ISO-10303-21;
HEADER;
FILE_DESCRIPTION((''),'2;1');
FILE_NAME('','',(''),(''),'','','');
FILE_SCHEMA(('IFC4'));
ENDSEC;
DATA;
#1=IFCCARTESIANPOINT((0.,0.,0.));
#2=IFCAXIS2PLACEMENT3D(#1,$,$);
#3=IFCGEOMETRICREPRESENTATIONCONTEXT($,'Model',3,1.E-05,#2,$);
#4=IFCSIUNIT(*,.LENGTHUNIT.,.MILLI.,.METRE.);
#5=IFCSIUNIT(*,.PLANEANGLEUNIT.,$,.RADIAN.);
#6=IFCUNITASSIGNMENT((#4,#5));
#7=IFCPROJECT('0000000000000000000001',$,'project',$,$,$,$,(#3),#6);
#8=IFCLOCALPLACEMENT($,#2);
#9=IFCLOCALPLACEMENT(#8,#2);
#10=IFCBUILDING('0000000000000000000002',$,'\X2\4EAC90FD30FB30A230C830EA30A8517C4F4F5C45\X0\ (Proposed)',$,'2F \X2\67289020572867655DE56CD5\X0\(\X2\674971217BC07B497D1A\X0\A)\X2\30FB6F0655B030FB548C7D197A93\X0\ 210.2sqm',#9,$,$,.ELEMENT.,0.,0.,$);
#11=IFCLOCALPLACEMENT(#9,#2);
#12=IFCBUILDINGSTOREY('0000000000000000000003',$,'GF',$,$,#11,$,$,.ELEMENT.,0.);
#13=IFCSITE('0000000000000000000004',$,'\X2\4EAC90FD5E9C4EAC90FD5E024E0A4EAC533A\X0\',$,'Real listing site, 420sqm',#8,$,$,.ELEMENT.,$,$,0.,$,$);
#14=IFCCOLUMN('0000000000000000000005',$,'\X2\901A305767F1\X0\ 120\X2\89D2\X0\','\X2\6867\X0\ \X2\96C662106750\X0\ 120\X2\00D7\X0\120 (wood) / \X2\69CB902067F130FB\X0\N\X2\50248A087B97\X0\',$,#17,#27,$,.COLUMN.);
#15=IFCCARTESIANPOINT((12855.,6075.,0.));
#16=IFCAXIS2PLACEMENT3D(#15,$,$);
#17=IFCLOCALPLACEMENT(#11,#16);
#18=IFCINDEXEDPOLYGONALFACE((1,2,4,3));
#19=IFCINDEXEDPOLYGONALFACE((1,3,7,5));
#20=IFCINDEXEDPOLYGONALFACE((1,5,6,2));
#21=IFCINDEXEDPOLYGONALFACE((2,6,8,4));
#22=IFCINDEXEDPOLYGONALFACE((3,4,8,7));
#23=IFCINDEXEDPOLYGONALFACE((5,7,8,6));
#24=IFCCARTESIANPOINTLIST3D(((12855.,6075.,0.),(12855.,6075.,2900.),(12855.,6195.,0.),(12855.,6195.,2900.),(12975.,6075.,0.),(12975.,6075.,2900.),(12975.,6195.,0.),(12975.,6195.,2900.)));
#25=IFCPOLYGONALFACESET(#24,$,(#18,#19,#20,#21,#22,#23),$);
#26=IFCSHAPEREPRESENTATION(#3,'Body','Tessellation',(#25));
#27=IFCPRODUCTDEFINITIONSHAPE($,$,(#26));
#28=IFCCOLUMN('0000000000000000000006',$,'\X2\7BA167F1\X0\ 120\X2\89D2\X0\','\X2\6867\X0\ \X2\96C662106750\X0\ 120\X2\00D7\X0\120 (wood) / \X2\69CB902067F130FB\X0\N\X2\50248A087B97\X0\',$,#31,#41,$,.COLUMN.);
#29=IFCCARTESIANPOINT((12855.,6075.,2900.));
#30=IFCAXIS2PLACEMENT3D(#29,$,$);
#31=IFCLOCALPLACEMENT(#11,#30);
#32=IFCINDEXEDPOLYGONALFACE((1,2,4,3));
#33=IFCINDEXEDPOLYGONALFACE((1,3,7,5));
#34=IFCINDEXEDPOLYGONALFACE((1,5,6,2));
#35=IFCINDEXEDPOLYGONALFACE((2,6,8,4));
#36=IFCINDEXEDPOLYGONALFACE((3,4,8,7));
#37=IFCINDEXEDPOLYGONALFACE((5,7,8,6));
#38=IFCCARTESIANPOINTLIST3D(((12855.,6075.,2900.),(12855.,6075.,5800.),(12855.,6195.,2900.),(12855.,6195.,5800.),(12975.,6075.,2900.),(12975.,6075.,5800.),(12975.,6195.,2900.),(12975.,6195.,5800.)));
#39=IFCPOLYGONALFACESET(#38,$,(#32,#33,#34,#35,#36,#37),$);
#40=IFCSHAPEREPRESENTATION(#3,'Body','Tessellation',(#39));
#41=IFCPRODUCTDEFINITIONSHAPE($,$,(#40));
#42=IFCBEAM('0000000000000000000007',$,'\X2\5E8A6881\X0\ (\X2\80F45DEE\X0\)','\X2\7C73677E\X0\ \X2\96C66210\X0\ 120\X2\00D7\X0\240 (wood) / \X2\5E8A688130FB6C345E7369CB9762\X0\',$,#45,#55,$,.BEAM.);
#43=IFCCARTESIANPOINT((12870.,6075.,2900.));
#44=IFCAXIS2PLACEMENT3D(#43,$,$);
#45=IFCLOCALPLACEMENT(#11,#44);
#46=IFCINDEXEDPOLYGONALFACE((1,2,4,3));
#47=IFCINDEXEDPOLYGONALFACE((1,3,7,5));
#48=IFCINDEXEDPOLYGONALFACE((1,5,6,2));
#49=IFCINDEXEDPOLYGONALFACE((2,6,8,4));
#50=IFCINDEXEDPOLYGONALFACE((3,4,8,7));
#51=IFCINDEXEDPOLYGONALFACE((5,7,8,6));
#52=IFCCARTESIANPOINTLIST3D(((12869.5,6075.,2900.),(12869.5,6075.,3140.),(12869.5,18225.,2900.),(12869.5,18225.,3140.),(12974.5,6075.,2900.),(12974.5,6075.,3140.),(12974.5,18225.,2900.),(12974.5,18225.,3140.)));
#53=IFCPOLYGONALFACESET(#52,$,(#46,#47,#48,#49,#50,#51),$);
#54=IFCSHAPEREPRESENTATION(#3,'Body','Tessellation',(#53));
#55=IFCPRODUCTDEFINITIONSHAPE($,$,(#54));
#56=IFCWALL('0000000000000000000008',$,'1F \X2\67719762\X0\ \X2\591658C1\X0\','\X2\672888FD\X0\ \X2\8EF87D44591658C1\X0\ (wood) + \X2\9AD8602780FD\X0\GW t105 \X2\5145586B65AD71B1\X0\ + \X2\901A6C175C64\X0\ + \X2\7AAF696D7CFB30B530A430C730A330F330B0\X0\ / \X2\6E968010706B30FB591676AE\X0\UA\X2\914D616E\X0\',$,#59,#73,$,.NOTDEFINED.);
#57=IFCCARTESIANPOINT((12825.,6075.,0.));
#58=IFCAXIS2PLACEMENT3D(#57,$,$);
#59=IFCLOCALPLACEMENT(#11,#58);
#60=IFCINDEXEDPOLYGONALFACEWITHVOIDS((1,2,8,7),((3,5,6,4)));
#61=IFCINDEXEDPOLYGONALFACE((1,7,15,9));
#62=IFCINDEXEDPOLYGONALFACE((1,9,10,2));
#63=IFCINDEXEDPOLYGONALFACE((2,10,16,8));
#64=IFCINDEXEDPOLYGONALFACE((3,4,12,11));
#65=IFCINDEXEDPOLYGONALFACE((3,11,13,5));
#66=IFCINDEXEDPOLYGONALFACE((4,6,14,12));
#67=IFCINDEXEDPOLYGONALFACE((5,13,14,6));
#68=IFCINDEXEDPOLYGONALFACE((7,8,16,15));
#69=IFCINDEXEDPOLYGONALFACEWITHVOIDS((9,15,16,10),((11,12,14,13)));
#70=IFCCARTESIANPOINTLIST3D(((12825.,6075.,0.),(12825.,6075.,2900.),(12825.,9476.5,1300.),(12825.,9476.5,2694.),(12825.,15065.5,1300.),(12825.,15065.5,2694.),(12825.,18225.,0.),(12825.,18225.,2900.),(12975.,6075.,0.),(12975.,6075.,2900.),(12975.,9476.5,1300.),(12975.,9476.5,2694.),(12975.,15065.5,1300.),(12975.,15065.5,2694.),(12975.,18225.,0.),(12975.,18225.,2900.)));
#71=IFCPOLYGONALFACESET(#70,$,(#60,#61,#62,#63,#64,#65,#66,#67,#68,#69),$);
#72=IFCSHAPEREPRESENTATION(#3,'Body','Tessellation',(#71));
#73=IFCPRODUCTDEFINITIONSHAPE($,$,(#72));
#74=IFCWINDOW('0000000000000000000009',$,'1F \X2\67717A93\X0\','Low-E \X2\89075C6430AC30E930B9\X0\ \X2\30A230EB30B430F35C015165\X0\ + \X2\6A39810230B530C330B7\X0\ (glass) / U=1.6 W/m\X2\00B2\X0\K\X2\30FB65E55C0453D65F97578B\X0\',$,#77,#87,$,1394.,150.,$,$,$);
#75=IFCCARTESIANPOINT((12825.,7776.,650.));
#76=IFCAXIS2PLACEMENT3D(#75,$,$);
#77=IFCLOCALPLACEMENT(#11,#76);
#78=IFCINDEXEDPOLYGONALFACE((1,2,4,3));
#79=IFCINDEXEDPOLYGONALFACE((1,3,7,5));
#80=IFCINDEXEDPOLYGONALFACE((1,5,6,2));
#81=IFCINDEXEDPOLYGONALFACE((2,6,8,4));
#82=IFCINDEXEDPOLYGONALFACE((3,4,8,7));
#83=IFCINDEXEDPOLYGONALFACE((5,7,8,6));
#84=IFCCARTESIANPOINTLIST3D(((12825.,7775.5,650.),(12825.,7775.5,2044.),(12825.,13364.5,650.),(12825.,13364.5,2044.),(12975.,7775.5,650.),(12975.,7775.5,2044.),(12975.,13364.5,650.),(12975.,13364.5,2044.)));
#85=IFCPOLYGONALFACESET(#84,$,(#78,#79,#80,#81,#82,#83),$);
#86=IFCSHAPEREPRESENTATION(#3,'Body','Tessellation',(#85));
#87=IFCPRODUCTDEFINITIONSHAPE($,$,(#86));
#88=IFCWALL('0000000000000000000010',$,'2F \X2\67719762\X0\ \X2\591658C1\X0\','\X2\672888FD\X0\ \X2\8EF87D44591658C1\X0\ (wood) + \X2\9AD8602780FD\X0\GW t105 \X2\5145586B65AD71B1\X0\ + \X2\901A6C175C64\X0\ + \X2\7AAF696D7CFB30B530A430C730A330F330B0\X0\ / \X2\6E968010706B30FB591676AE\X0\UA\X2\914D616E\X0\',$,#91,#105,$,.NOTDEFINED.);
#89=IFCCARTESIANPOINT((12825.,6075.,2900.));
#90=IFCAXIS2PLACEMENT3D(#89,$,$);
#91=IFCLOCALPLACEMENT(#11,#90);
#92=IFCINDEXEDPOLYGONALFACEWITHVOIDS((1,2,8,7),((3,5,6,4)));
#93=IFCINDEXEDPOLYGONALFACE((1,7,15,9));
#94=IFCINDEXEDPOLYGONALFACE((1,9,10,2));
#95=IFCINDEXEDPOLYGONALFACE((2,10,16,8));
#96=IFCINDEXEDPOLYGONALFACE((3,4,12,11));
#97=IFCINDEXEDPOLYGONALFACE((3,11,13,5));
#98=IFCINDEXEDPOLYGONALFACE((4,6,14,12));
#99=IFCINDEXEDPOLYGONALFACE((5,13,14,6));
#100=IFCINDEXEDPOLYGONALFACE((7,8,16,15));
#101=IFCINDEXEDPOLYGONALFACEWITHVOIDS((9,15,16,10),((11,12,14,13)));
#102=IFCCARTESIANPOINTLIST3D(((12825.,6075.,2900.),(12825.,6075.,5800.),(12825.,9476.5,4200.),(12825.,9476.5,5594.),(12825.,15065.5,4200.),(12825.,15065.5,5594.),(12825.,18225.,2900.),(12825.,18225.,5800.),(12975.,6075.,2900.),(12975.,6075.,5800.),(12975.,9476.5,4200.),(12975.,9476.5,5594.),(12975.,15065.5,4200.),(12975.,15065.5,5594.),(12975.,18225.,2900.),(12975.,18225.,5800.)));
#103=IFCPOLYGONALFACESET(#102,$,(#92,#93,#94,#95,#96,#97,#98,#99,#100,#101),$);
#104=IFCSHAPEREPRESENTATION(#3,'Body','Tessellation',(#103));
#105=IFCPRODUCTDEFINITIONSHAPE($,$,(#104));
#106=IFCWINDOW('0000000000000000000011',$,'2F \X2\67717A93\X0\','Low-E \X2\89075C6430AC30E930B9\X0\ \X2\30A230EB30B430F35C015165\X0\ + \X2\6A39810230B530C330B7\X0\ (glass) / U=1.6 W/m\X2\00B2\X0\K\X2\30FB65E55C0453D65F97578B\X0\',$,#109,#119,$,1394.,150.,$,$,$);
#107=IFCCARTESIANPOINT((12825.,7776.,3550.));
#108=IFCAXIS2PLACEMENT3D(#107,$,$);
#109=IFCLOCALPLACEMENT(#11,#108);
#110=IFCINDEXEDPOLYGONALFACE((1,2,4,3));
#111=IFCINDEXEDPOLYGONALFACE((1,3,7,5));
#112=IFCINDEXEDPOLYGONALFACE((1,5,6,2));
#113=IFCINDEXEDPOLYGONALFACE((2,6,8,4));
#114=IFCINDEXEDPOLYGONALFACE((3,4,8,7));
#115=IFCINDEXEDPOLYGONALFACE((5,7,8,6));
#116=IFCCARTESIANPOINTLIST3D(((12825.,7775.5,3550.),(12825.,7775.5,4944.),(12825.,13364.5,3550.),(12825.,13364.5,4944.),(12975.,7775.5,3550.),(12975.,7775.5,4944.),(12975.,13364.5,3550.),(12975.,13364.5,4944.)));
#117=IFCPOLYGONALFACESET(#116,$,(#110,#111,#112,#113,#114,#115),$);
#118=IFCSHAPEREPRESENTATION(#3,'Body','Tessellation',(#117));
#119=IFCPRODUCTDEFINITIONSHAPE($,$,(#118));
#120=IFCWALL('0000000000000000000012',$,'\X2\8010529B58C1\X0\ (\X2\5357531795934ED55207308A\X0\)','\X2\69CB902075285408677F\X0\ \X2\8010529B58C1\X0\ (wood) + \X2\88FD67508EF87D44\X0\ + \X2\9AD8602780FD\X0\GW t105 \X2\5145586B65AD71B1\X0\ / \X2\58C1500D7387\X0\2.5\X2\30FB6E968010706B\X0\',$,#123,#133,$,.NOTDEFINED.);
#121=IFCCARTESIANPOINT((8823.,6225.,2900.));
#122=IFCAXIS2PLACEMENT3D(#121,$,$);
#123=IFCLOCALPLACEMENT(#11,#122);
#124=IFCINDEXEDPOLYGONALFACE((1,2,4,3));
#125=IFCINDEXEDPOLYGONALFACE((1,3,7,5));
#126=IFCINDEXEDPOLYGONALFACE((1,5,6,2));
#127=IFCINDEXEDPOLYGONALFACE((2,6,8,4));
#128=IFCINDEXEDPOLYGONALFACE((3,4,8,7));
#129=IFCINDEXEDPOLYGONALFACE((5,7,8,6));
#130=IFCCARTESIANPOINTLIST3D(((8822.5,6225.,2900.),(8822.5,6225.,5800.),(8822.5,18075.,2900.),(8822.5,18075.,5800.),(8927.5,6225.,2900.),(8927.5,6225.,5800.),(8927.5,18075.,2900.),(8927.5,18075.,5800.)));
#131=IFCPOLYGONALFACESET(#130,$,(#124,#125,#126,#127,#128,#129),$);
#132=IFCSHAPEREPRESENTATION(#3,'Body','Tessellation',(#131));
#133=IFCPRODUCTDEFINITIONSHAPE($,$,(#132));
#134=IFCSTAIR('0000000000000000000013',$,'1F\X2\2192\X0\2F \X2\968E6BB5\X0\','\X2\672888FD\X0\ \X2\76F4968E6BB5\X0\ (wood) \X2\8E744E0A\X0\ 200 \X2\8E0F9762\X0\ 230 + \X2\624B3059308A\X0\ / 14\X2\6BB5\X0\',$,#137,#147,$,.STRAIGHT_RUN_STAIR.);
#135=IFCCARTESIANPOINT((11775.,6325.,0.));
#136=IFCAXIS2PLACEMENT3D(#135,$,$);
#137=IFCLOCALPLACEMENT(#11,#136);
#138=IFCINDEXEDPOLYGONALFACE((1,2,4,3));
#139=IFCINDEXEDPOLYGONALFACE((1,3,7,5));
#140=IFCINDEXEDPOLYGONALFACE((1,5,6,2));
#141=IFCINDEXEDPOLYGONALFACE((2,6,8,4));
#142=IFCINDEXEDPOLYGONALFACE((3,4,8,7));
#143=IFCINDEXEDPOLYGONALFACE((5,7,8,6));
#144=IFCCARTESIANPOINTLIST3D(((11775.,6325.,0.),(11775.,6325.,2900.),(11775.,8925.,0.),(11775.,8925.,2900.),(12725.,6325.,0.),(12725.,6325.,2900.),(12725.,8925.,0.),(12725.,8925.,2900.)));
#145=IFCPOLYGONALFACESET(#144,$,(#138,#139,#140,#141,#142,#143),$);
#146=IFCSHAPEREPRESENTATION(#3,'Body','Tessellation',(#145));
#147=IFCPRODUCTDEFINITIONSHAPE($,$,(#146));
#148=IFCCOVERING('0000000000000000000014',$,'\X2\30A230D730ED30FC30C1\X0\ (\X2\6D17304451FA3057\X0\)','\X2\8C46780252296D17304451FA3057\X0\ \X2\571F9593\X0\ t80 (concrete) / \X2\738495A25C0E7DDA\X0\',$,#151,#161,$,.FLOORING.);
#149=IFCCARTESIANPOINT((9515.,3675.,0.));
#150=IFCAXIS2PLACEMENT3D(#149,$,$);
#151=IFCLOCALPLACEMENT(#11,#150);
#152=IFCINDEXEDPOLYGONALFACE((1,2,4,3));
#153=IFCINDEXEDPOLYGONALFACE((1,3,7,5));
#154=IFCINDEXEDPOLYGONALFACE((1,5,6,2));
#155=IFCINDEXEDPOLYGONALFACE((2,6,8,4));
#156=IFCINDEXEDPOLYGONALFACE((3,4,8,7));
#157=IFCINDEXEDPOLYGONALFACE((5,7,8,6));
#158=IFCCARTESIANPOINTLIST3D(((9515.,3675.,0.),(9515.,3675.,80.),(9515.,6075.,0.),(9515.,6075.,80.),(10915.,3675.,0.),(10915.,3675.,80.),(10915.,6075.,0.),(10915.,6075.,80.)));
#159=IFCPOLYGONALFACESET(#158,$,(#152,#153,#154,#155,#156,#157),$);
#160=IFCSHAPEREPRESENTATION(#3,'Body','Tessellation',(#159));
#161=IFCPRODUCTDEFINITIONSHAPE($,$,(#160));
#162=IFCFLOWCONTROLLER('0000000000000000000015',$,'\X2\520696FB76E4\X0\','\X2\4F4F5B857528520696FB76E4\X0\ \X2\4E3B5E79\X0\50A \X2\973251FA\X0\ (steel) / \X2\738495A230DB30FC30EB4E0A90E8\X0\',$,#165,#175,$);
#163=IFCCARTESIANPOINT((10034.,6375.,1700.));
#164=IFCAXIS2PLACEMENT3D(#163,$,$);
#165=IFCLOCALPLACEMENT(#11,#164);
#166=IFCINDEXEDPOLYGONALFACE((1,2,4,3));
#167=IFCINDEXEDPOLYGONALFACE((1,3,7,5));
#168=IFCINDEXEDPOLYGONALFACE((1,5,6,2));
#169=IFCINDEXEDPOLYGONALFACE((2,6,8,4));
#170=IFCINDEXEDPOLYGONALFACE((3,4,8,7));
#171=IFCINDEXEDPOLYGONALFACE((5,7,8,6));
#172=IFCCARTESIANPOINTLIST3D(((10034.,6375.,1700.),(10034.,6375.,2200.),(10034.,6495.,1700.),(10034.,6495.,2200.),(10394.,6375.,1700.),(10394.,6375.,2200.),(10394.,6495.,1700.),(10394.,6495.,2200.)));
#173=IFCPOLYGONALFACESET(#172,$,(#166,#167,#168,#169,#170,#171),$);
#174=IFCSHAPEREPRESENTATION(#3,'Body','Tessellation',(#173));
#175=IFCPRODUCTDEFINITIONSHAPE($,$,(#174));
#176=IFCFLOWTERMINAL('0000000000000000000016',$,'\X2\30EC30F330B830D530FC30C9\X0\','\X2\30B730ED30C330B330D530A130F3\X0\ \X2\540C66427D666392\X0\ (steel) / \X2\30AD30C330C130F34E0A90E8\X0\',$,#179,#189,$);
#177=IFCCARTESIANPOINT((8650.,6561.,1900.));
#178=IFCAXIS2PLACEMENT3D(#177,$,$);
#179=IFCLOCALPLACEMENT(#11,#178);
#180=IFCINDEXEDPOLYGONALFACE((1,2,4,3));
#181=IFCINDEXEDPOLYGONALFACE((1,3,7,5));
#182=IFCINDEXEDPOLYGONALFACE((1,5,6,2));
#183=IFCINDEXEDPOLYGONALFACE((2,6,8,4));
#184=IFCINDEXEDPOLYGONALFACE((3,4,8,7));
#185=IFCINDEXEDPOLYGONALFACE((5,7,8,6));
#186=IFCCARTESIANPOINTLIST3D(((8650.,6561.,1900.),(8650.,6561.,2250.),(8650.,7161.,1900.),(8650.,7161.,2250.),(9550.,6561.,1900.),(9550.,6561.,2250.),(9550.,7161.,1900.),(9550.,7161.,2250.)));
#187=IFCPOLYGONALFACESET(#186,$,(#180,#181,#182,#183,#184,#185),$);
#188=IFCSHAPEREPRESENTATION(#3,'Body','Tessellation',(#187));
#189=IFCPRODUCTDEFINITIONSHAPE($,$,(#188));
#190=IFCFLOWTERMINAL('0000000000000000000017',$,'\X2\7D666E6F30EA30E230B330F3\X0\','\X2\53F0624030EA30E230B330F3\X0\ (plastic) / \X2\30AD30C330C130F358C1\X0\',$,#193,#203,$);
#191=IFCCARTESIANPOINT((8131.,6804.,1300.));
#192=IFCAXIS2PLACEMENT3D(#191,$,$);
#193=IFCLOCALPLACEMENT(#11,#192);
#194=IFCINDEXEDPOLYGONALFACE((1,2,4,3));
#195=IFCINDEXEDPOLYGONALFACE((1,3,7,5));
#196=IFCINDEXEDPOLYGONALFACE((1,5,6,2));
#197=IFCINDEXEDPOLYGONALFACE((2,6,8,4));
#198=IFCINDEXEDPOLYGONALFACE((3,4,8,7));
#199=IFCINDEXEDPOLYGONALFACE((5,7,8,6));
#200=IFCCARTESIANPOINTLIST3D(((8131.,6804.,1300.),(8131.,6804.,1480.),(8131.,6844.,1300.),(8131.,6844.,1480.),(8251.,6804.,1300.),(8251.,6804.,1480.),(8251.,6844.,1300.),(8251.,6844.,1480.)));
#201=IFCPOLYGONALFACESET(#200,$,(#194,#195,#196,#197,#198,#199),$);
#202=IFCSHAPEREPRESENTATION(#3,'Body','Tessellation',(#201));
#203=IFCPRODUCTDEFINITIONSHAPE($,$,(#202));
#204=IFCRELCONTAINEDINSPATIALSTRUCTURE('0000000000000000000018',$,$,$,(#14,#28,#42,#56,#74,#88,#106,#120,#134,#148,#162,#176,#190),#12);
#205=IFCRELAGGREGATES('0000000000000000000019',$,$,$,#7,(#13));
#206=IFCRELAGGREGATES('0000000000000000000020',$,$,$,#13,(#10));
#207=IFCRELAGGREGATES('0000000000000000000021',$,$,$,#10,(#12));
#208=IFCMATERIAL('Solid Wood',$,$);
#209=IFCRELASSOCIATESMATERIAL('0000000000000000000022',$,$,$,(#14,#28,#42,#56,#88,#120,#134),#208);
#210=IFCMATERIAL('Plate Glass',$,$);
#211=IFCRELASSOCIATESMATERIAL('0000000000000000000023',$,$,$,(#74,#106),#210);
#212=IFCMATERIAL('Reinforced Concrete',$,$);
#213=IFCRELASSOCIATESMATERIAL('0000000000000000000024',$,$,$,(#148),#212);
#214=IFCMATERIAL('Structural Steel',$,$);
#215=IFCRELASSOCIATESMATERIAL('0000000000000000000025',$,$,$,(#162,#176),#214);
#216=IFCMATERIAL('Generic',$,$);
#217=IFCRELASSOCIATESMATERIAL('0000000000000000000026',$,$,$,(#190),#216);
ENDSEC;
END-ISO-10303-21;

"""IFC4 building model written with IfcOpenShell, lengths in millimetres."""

from ifc_helpers import new_model, si_unit, frame, frame_2d, origin, place, context, project, spatial, rectangle, extrude, material, element, fill, save


model = new_model("IFC4")

# Units and contexts
model_context = context("Model", 3, precision=1e-05, world=origin())
ifc_project = project(units=[si_unit("LENGTHUNIT", "METRE", prefix="MILLI"), si_unit("PLANEANGLEUNIT", "RADIAN")], contexts=[model_context])

# Site, building, storey
site_placement = place(None, origin())
site = spatial("IfcSite", under=ifc_project, at=site_placement, Name="京都府京都市上京区", ObjectType="Real listing site, 420sqm", CompositionType="ELEMENT", RefElevation=0.0)
building_placement = place(site_placement, origin())
building = spatial("IfcBuilding", under=site, at=building_placement, Name="京都・アトリエ兼住居 (Proposed)", ObjectType="2F 木造在来工法(杉無節等級A)・漆喰・和紙窓 210.2sqm", CompositionType="ELEMENT", ElevationOfRefHeight=0.0, ElevationOfTerrain=0.0)
storey_placement = place(building_placement, origin())
storey = spatial("IfcBuildingStorey", under=building, at=storey_placement, Name="GF", CompositionType="ELEMENT", Elevation=0.0)

# Columns
ifc_material_1 = material(Name="Solid Wood")
column_1_placement = place(storey_placement, frame((12855.0, 6075.0, 0.0)))
element("IfcColumn", 1, at=column_1_placement, inside=storey, material=ifc_material_1, Name="通し柱 120角", Description="桧 集成材 120×120 (wood) / 構造柱・N値計算", PredefinedType="COLUMN", context=model_context, shape_type="SweptSolid", body=[
    extrude(rectangle(XDim=120.0, YDim=120.0, at=frame_2d((60.0, 60.0))), frame((12855.0, 6075.0, 0.0)), (0.0, 0.0, 1.0), 2900.0),
])
column_2_placement = place(storey_placement, frame((12855.0, 6075.0, 2900.0)))
element("IfcColumn", 2, at=column_2_placement, inside=storey, material=ifc_material_1, Name="管柱 120角", Description="桧 集成材 120×120 (wood) / 構造柱・N値計算", PredefinedType="COLUMN", context=model_context, shape_type="SweptSolid", body=[
    extrude(rectangle(XDim=120.0, YDim=120.0, at=frame_2d((60.0, 60.0))), frame((12855.0, 6075.0, 2900.0)), (0.0, 0.0, 1.0), 2900.0),
])

# Beam
beam_1_placement = place(storey_placement, frame((12870.0, 6075.0, 2900.0)))
element("IfcBeam", 3, at=beam_1_placement, inside=storey, material=ifc_material_1, Name="床梁 (胴差)", Description="米松 集成 120×240 (wood) / 床梁・水平構面", PredefinedType="BEAM", context=model_context, shape_type="SweptSolid", body=[
    extrude(rectangle(XDim=105.0, YDim=12150.0, at=frame_2d((52.0, 6075.0))), frame((12870.0, 6075.0, 2900.0)), (0.0, 0.0, 1.0), 240.0),
])

# Wall, opening, window
wall_1_placement = place(storey_placement, frame((12825.0, 6075.0, 0.0)))
wall_1 = element("IfcWall", 4, at=wall_1_placement, inside=storey, material=ifc_material_1, Name="1F 東面 外壁", Description="木製 軸組外壁 (wood) + 高性能GW t105 充填断熱 + 通気層 + 窯業系サイディング / 準耐火・外皮UA配慮", PredefinedType="NOTDEFINED", context=model_context, shape_type="SweptSolid", body=[
    extrude(rectangle(XDim=150.0, YDim=12150.0, at=frame_2d((75.0, 6075.0))), frame((12825.0, 6075.0, 0.0)), (0.0, 0.0, 1.0), 2900.0),
])
opening_1_placement = place(storey_placement, frame((12825.0, 7776.0, 650.0)))
opening_1 = element("IfcOpeningElement", 5, at=opening_1_placement, cuts=wall_1, PredefinedType="NOTDEFINED", context=model_context, shape_type="SweptSolid", body=[
    extrude(rectangle(XDim=150.0, YDim=5589.0, at=frame_2d((75.0, 2794.0))), frame((12825.0, 7776.0, 650.0)), (0.0, 0.0, 1.0), 1394.0),
])
ifc_material_2 = material(Name="Plate Glass")
window_1_placement = place(storey_placement, frame((12825.0, 7776.0, 650.0)))
window_1 = element("IfcWindow", 6, at=window_1_placement, inside=storey, material=ifc_material_2, Name="1F 東窓", Description="Low-E 複層ガラス アルゴン封入 + 樹脂サッシ (glass) / U=1.6 W/m²K・日射取得型", OverallHeight=1394.0, OverallWidth=150.0, context=model_context, shape_type="SweptSolid", body=[
    extrude(rectangle(XDim=150.0, YDim=5589.0, at=frame_2d((75.0, 2794.0))), frame((12825.0, 7776.0, 650.0)), (0.0, 0.0, 1.0), 1394.0),
])
fill(opening_1, window_1)

# Wall, opening, window
wall_2_placement = place(storey_placement, frame((12825.0, 6075.0, 2900.0)))
wall_2 = element("IfcWall", 7, at=wall_2_placement, inside=storey, material=ifc_material_1, Name="2F 東面 外壁", Description="木製 軸組外壁 (wood) + 高性能GW t105 充填断熱 + 通気層 + 窯業系サイディング / 準耐火・外皮UA配慮", PredefinedType="NOTDEFINED", context=model_context, shape_type="SweptSolid", body=[
    extrude(rectangle(XDim=150.0, YDim=12150.0, at=frame_2d((75.0, 6075.0))), frame((12825.0, 6075.0, 2900.0)), (0.0, 0.0, 1.0), 2900.0),
])
opening_2_placement = place(storey_placement, frame((12825.0, 7776.0, 3550.0)))
opening_2 = element("IfcOpeningElement", 8, at=opening_2_placement, cuts=wall_2, PredefinedType="NOTDEFINED", context=model_context, shape_type="SweptSolid", body=[
    extrude(rectangle(XDim=150.0, YDim=5589.0, at=frame_2d((75.0, 2794.0))), frame((12825.0, 7776.0, 3550.0)), (0.0, 0.0, 1.0), 1394.0),
])
window_2_placement = place(storey_placement, frame((12825.0, 7776.0, 3550.0)))
window_2 = element("IfcWindow", 9, at=window_2_placement, inside=storey, material=ifc_material_2, Name="2F 東窓", Description="Low-E 複層ガラス アルゴン封入 + 樹脂サッシ (glass) / U=1.6 W/m²K・日射取得型", OverallHeight=1394.0, OverallWidth=150.0, context=model_context, shape_type="SweptSolid", body=[
    extrude(rectangle(XDim=150.0, YDim=5589.0, at=frame_2d((75.0, 2794.0))), frame((12825.0, 7776.0, 3550.0)), (0.0, 0.0, 1.0), 1394.0),
])
fill(opening_2, window_2)

# Wall
wall_3_placement = place(storey_placement, frame((8823.0, 6225.0, 2900.0)))
element("IfcWall", 10, at=wall_3_placement, inside=storey, material=ifc_material_1, Name="耐力壁 (南北間仕切り)", Description="構造用合板 耐力壁 (wood) + 製材軸組 + 高性能GW t105 充填断熱 / 壁倍率2.5・準耐火", PredefinedType="NOTDEFINED", context=model_context, shape_type="SweptSolid", body=[
    extrude(rectangle(XDim=105.0, YDim=11850.0, at=frame_2d((52.0, 5925.0))), frame((8823.0, 6225.0, 2900.0)), (0.0, 0.0, 1.0), 2900.0),
])

# Stair
stair_placement = place(storey_placement, frame((11775.0, 6325.0, 0.0)))
element("IfcStair", 11, at=stair_placement, inside=storey, material=ifc_material_1, Name="1F→2F 階段", Description="木製 直階段 (wood) 蹴上 200 踏面 230 + 手すり / 14段", PredefinedType="STRAIGHT_RUN_STAIR", context=model_context, shape_type="SweptSolid", body=[
    extrude(rectangle(XDim=950.0, YDim=2600.0, at=frame_2d((475.0, 1300.0))), frame((11775.0, 6325.0, 0.0)), (0.0, 0.0, 1.0), 2900.0),
])

# Covering
ifc_material_3 = material(Name="Reinforced Concrete")
covering_placement = place(storey_placement, frame((9515.0, 3675.0, 0.0)))
element("IfcCovering", 12, at=covering_placement, inside=storey, material=ifc_material_3, Name="アプローチ (洗い出し)", Description="豆砂利洗い出し 土間 t80 (concrete) / 玄関導線", PredefinedType="FLOORING", context=model_context, shape_type="SweptSolid", body=[
    extrude(rectangle(XDim=1400.0, YDim=2400.0, at=frame_2d((700.0, 1200.0))), frame((9515.0, 3675.0, 0.0)), (0.0, 0.0, 1.0), 80.0),
])

# Flow controller
ifc_material_4 = material(Name="Structural Steel")
flow_controller_placement = place(storey_placement, frame((10034.0, 6375.0, 1700.0)))
element("IfcFlowController", 13, at=flow_controller_placement, inside=storey, material=ifc_material_4, Name="分電盤", Description="住宅用分電盤 主幹50A 露出 (steel) / 玄関ホール上部", context=model_context, shape_type="SweptSolid", body=[
    extrude(rectangle(XDim=360.0, YDim=120.0, at=frame_2d((180.0, 60.0))), frame((10034.0, 6375.0, 1700.0)), (0.0, 0.0, 1.0), 500.0),
])

# Flow terminals
flow_terminal_1_placement = place(storey_placement, frame((8650.0, 6561.0, 1900.0)))
element("IfcFlowTerminal", 14, at=flow_terminal_1_placement, inside=storey, material=ifc_material_4, Name="レンジフード", Description="シロッコファン 同時給排 (steel) / キッチン上部", context=model_context, shape_type="SweptSolid", body=[
    extrude(rectangle(XDim=900.0, YDim=600.0, at=frame_2d((450.0, 300.0))), frame((8650.0, 6561.0, 1900.0)), (0.0, 0.0, 1.0), 350.0),
])
ifc_material_5 = material(Name="Generic")
flow_terminal_2_placement = place(storey_placement, frame((8131.0, 6804.0, 1300.0)))
element("IfcFlowTerminal", 15, at=flow_terminal_2_placement, inside=storey, material=ifc_material_5, Name="給湯リモコン", Description="台所リモコン (plastic) / キッチン壁", context=model_context, shape_type="SweptSolid", body=[
    extrude(rectangle(XDim=120.0, YDim=40.0, at=frame_2d((60.0, 20.0))), frame((8131.0, 6804.0, 1300.0)), (0.0, 0.0, 1.0), 180.0),
])

save(model, "model.ifc")
